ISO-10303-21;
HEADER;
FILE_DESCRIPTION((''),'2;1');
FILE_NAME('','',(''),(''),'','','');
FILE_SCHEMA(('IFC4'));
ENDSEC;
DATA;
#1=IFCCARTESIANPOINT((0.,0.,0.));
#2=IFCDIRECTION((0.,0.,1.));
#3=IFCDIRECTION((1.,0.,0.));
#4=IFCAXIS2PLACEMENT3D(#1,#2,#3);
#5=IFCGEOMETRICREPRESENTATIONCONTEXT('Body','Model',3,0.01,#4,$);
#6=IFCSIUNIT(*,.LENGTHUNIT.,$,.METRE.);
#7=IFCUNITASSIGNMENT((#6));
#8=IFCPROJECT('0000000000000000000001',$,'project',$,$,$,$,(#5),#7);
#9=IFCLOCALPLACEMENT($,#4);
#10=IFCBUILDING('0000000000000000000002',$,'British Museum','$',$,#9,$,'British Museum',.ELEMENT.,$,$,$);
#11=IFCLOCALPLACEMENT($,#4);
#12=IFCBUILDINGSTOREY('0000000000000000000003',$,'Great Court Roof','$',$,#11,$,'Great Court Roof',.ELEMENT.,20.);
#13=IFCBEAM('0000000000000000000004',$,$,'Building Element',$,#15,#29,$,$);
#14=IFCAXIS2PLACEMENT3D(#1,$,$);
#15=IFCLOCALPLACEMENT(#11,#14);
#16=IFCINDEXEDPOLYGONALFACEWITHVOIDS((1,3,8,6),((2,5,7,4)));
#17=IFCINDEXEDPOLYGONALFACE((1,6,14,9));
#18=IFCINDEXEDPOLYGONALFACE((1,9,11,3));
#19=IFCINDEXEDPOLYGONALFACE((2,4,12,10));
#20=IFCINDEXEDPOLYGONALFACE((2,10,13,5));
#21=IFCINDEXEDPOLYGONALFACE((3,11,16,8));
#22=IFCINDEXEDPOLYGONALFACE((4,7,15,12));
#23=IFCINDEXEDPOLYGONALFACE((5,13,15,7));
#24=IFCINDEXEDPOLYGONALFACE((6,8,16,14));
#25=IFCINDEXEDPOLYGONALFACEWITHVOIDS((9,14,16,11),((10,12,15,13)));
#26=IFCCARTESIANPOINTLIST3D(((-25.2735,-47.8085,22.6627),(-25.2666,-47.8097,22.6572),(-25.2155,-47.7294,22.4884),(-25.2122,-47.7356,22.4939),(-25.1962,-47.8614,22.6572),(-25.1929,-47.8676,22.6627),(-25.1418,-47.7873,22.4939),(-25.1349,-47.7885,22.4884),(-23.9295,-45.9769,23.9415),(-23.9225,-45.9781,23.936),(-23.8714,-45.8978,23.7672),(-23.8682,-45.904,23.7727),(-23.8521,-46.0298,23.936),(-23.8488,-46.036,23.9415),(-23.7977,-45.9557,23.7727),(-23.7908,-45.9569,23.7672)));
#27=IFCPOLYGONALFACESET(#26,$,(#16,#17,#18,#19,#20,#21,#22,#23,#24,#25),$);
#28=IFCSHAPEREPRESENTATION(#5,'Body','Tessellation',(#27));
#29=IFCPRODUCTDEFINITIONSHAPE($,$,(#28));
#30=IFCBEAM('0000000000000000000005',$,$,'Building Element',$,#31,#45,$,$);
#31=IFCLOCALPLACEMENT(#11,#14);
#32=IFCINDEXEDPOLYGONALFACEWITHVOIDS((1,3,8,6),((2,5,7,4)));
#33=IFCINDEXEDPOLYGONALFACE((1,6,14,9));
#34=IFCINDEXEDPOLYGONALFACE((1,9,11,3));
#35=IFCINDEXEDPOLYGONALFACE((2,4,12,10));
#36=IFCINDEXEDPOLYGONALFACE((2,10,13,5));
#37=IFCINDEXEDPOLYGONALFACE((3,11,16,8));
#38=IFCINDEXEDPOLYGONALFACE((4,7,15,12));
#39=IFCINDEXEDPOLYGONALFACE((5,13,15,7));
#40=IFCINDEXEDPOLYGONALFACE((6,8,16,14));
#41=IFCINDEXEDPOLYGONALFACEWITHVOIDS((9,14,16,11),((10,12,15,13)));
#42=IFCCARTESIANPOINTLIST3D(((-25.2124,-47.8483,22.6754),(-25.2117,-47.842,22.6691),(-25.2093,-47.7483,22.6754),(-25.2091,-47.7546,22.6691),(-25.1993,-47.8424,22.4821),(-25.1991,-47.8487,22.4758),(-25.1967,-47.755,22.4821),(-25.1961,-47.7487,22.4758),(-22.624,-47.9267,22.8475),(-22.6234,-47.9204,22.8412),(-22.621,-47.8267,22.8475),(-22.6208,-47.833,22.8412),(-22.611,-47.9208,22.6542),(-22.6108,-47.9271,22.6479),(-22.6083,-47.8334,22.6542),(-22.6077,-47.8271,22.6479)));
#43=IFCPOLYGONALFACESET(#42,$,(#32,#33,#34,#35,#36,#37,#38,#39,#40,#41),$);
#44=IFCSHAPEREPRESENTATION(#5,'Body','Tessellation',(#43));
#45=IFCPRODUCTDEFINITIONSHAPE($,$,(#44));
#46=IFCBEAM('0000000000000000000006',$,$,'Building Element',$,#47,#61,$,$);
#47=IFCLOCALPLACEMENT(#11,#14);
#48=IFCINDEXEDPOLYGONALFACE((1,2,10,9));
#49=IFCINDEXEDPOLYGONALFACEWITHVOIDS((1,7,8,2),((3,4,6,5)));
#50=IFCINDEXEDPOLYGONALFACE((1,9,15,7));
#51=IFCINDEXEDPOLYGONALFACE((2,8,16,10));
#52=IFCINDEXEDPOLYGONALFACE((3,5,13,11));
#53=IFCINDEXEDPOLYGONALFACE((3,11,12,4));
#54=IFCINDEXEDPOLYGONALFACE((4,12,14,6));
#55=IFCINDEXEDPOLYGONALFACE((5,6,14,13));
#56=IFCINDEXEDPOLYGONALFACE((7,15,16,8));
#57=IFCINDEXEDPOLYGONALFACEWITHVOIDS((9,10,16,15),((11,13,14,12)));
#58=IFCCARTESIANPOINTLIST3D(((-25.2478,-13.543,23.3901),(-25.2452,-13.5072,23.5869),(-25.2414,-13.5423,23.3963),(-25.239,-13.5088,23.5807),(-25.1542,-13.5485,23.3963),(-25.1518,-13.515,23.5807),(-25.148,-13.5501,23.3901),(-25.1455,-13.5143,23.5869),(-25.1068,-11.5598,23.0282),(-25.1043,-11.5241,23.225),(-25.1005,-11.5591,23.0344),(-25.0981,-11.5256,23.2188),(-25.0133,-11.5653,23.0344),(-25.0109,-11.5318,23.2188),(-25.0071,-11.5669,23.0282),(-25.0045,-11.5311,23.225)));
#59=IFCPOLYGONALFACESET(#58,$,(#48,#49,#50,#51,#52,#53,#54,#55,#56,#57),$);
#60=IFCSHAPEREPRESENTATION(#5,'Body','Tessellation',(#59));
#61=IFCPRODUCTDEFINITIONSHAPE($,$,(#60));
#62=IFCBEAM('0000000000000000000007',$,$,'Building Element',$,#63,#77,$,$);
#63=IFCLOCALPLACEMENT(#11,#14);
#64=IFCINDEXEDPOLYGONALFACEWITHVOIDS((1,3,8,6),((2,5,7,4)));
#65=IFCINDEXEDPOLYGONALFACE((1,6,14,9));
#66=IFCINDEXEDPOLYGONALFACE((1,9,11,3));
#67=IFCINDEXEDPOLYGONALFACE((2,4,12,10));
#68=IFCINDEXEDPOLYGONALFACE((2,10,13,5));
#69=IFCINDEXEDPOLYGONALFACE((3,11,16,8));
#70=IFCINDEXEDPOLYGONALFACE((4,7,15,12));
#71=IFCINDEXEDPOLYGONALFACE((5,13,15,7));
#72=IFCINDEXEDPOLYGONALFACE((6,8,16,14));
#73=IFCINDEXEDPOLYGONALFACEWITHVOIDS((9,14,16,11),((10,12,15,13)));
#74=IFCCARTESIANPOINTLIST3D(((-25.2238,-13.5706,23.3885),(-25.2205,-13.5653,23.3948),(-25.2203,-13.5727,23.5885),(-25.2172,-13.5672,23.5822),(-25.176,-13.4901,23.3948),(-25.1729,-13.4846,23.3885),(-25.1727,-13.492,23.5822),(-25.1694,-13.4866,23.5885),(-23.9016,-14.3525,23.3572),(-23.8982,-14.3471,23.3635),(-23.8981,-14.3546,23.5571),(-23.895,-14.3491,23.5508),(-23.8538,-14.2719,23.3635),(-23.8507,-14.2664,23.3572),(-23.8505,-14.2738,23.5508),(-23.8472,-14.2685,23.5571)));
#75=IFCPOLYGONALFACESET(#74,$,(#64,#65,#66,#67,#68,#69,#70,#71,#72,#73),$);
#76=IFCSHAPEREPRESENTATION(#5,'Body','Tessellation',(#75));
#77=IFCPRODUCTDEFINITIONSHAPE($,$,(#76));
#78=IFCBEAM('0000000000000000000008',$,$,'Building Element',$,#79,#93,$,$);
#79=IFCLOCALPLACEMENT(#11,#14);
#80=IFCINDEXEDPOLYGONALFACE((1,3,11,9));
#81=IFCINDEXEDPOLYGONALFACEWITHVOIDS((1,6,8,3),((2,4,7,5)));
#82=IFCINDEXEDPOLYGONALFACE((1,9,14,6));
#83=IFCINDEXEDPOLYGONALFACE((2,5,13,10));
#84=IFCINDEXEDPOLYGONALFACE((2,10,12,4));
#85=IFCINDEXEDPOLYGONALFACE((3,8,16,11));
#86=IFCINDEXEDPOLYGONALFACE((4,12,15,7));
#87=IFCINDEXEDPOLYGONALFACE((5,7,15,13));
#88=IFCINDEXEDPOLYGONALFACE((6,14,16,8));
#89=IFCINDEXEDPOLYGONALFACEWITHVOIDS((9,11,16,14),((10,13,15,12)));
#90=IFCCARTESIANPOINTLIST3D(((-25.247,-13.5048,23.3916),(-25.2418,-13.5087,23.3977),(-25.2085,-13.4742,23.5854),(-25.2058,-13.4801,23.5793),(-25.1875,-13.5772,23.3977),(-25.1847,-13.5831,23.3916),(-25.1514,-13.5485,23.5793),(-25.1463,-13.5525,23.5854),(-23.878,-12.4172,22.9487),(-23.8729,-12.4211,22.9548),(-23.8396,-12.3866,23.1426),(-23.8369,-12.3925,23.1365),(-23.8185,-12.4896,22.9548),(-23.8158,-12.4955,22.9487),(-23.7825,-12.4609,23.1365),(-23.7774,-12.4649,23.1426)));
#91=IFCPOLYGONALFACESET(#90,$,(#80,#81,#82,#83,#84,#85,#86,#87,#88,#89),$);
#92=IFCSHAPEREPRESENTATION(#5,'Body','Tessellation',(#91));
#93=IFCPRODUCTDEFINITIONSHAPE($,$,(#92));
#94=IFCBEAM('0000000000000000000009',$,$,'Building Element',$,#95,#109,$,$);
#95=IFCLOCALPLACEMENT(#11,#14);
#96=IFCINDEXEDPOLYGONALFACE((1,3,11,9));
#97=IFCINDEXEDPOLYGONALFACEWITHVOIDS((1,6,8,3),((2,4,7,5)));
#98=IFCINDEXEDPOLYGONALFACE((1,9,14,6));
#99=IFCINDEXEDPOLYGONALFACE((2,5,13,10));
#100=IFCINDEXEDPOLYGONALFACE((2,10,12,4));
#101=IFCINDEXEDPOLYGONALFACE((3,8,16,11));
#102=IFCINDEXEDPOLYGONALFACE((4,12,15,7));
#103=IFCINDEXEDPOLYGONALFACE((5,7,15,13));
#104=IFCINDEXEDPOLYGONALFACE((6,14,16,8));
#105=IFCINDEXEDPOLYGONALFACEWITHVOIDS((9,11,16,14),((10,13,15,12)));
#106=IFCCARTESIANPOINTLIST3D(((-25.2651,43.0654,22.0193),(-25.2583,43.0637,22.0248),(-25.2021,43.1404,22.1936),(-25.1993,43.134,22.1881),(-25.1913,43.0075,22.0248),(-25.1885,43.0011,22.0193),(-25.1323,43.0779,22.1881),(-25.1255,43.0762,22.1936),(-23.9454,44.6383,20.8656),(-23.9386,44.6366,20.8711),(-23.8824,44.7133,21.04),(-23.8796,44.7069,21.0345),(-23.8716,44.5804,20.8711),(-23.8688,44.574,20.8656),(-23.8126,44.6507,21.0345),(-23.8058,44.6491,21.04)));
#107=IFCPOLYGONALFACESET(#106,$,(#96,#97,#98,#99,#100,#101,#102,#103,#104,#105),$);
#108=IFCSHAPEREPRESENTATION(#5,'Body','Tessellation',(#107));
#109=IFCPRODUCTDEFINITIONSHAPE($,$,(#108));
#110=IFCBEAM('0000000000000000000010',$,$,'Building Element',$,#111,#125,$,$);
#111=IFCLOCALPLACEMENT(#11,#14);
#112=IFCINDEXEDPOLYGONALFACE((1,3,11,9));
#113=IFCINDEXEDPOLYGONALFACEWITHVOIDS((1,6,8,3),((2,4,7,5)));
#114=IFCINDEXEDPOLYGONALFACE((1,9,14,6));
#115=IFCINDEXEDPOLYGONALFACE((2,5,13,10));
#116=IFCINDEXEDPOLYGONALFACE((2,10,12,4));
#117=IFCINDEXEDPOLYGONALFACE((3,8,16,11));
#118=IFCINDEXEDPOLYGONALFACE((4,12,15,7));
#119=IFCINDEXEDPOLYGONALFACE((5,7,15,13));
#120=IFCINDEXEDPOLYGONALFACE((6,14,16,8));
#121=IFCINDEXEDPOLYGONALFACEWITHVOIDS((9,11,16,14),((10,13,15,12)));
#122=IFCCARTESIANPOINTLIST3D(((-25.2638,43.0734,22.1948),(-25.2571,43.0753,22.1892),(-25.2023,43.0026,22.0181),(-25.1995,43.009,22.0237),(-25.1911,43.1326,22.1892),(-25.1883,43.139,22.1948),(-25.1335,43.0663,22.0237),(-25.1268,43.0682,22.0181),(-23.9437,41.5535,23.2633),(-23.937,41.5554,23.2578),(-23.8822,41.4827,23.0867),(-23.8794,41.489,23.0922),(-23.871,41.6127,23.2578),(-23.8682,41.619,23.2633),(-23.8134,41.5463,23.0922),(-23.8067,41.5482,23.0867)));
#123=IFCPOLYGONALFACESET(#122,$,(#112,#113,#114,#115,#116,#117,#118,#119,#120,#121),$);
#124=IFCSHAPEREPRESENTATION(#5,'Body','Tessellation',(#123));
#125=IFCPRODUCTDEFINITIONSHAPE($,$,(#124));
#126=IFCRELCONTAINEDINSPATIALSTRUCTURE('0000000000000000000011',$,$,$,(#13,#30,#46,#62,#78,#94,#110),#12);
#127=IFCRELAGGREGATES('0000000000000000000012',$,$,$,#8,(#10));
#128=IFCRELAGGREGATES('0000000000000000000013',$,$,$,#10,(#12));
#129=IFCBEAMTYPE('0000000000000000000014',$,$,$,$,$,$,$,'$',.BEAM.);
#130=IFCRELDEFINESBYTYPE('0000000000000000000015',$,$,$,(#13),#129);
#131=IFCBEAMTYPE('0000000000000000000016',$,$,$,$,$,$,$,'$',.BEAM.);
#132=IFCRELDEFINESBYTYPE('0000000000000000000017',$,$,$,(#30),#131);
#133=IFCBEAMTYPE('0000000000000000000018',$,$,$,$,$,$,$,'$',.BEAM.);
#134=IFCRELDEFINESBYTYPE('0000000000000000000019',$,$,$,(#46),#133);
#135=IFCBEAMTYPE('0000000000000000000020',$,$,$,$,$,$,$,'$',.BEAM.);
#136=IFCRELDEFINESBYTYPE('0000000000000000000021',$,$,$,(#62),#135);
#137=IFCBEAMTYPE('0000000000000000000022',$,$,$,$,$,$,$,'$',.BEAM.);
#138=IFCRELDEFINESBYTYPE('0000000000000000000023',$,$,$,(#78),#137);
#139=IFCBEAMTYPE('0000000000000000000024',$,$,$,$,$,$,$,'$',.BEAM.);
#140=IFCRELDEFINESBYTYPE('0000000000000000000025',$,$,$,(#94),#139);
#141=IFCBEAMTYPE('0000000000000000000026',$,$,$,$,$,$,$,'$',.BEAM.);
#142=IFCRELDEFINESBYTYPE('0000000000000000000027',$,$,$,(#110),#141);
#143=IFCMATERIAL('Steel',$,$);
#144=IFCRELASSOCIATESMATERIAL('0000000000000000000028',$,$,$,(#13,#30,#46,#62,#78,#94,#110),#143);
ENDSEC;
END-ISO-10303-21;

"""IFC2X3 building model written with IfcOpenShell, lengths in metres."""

from ifc_helpers import new_model, si_unit, frame, origin_with_axes, origin_2d, place, context, project, spatial, hollow_rectangle, extrude, material, type_object, element, save


model = new_model("IFC2X3")

# Units and contexts
model_context = context("Model", 3, precision=0.01, world=origin_with_axes(), identifier="Body")
ifc_project = project(units=[si_unit("LENGTHUNIT", "METRE")], contexts=[model_context])

# Building, storey
building_placement = place(None, origin_with_axes())
building = spatial("IfcBuilding", under=ifc_project, at=building_placement, Name="British Museum", Description="$", LongName="British Museum", CompositionType="ELEMENT")
storey_placement = place(None, origin_with_axes())
storey = spatial("IfcBuildingStorey", under=building, at=storey_placement, Name="Great Court Roof", Description="$", LongName="Great Court Roof", CompositionType="ELEMENT", Elevation=20.0)

# Beams
ifc_material = material(Name="Steel")
beam_type_1 = type_object("IfcBeamType", ElementType="$", PredefinedType="BEAM")
beam_1_placement = place(None, origin_with_axes())
element("IfcBeam", 1, at=beam_1_placement, inside=storey, type_object=beam_type_1, material=ifc_material, Description="Building Element", context=model_context, shape_type="SweptSolid", body=[
    extrude(hollow_rectangle(XDim=0.1, YDim=0.2, WallThickness=0.0063, InnerFilletRadius=-0.0063, OuterFilletRadius=0.0, at=origin_2d()), frame((-25.2042, -47.7985, 22.5756), z_axis=(0.515568, 0.702568, 0.490497), x_axis=(-0.806212, 0.591626, 0.0)), (0.0, 0.0, 1.0), 2.607),
])
beam_type_2 = type_object("IfcBeamType", ElementType="$", PredefinedType="BEAM")
beam_2_placement = place(None, origin_with_axes())
element("IfcBeam", 2, at=beam_2_placement, inside=storey, type_object=beam_type_2, material=ifc_material, Description="Building Element", context=model_context, shape_type="SweptSolid", body=[
    extrude(hollow_rectangle(XDim=0.1, YDim=0.2, WallThickness=0.0063, InnerFilletRadius=-0.0063, OuterFilletRadius=0.0, at=origin_2d()), frame((-25.2042, -47.7985, 22.5756), z_axis=(0.997341, -0.030214, 0.066318), x_axis=(0.030281, 0.999541, 0.0)), (0.0, 0.0, 1.0), 2.5952),
])
beam_type_3 = type_object("IfcBeamType", ElementType="$", PredefinedType="BEAM")
beam_3_placement = place(None, origin_with_axes())
element("IfcBeam", 3, at=beam_3_placement, inside=storey, type_object=beam_type_3, material=ifc_material, Description="Building Element", context=model_context, shape_type="SweptSolid", body=[
    extrude(hollow_rectangle(XDim=0.1, YDim=0.2, WallThickness=0.0063, InnerFilletRadius=-0.0063, OuterFilletRadius=0.0, at=origin_2d()), frame((-25.1966, -13.5286, 23.4885), z_axis=(0.069744, 0.981358, -0.17909), x_axis=(-0.997484, 0.07089, 0.0)), (0.0, 0.0, 1.0), 2.0209),
])
beam_type_4 = type_object("IfcBeamType", ElementType="$", PredefinedType="BEAM")
beam_4_placement = place(None, origin_with_axes())
element("IfcBeam", 4, at=beam_4_placement, inside=storey, type_object=beam_type_4, material=ifc_material, Description="Building Element", context=model_context, shape_type="SweptSolid", body=[
    extrude(hollow_rectangle(XDim=0.1, YDim=0.2, WallThickness=0.0063, InnerFilletRadius=-0.0063, OuterFilletRadius=0.0, at=origin_2d()), frame((-25.1966, -13.5286, 23.4885), z_axis=(0.860604, -0.508865, -0.020404), x_axis=(0.508971, 0.860784, 0.0)), (0.0, 0.0, 1.0), 1.5364),
])
beam_type_5 = type_object("IfcBeamType", ElementType="$", PredefinedType="BEAM")
beam_5_placement = place(None, origin_with_axes())
element("IfcBeam", 5, at=beam_5_placement, inside=storey, type_object=beam_type_5, material=ifc_material, Description="Building Element", context=model_context, shape_type="SweptSolid", body=[
    extrude(hollow_rectangle(XDim=0.1, YDim=0.2, WallThickness=0.0063, InnerFilletRadius=-0.0063, OuterFilletRadius=0.0, at=origin_2d()), frame((-25.1966, -13.5286, 23.4885), z_axis=(0.758991, 0.603025, -0.245547), x_axis=(-0.62207, 0.782962, 0.0)), (0.0, 0.0, 1.0), 1.8036),
])
beam_type_6 = type_object("IfcBeamType", ElementType="$", PredefinedType="BEAM")
beam_6_placement = place(None, origin_with_axes())
element("IfcBeam", 6, at=beam_6_placement, inside=storey, type_object=beam_type_6, material=ifc_material, Description="Building Element", context=model_context, shape_type="SweptSolid", body=[
    extrude(hollow_rectangle(XDim=0.1, YDim=0.2, WallThickness=0.0063, InnerFilletRadius=-0.0063, OuterFilletRadius=0.0, at=origin_2d()), frame((-25.1953, 43.0708, 22.1065), z_axis=(0.560354, 0.667867, -0.489855), x_axis=(-0.766074, 0.642752, 0.0)), (0.0, 0.0, 1.0), 2.3551),
])
beam_type_7 = type_object("IfcBeamType", ElementType="$", PredefinedType="BEAM")
beam_7_placement = place(None, origin_with_axes())
element("IfcBeam", 7, at=beam_7_placement, inside=storey, type_object=beam_type_7, material=ifc_material, Description="Building Element", context=model_context, shape_type="SweptSolid", body=[
    extrude(hollow_rectangle(XDim=0.1, YDim=0.2, WallThickness=0.0063, InnerFilletRadius=-0.0063, OuterFilletRadius=0.0, at=origin_2d()), frame((-25.1953, 43.0708, 22.1065), z_axis=(0.579206, -0.666874, 0.468828), x_axis=(0.754989, 0.655737, 0.0)), (0.0, 0.0, 1.0), 2.2792),
])

save(model, "model.ifc")
